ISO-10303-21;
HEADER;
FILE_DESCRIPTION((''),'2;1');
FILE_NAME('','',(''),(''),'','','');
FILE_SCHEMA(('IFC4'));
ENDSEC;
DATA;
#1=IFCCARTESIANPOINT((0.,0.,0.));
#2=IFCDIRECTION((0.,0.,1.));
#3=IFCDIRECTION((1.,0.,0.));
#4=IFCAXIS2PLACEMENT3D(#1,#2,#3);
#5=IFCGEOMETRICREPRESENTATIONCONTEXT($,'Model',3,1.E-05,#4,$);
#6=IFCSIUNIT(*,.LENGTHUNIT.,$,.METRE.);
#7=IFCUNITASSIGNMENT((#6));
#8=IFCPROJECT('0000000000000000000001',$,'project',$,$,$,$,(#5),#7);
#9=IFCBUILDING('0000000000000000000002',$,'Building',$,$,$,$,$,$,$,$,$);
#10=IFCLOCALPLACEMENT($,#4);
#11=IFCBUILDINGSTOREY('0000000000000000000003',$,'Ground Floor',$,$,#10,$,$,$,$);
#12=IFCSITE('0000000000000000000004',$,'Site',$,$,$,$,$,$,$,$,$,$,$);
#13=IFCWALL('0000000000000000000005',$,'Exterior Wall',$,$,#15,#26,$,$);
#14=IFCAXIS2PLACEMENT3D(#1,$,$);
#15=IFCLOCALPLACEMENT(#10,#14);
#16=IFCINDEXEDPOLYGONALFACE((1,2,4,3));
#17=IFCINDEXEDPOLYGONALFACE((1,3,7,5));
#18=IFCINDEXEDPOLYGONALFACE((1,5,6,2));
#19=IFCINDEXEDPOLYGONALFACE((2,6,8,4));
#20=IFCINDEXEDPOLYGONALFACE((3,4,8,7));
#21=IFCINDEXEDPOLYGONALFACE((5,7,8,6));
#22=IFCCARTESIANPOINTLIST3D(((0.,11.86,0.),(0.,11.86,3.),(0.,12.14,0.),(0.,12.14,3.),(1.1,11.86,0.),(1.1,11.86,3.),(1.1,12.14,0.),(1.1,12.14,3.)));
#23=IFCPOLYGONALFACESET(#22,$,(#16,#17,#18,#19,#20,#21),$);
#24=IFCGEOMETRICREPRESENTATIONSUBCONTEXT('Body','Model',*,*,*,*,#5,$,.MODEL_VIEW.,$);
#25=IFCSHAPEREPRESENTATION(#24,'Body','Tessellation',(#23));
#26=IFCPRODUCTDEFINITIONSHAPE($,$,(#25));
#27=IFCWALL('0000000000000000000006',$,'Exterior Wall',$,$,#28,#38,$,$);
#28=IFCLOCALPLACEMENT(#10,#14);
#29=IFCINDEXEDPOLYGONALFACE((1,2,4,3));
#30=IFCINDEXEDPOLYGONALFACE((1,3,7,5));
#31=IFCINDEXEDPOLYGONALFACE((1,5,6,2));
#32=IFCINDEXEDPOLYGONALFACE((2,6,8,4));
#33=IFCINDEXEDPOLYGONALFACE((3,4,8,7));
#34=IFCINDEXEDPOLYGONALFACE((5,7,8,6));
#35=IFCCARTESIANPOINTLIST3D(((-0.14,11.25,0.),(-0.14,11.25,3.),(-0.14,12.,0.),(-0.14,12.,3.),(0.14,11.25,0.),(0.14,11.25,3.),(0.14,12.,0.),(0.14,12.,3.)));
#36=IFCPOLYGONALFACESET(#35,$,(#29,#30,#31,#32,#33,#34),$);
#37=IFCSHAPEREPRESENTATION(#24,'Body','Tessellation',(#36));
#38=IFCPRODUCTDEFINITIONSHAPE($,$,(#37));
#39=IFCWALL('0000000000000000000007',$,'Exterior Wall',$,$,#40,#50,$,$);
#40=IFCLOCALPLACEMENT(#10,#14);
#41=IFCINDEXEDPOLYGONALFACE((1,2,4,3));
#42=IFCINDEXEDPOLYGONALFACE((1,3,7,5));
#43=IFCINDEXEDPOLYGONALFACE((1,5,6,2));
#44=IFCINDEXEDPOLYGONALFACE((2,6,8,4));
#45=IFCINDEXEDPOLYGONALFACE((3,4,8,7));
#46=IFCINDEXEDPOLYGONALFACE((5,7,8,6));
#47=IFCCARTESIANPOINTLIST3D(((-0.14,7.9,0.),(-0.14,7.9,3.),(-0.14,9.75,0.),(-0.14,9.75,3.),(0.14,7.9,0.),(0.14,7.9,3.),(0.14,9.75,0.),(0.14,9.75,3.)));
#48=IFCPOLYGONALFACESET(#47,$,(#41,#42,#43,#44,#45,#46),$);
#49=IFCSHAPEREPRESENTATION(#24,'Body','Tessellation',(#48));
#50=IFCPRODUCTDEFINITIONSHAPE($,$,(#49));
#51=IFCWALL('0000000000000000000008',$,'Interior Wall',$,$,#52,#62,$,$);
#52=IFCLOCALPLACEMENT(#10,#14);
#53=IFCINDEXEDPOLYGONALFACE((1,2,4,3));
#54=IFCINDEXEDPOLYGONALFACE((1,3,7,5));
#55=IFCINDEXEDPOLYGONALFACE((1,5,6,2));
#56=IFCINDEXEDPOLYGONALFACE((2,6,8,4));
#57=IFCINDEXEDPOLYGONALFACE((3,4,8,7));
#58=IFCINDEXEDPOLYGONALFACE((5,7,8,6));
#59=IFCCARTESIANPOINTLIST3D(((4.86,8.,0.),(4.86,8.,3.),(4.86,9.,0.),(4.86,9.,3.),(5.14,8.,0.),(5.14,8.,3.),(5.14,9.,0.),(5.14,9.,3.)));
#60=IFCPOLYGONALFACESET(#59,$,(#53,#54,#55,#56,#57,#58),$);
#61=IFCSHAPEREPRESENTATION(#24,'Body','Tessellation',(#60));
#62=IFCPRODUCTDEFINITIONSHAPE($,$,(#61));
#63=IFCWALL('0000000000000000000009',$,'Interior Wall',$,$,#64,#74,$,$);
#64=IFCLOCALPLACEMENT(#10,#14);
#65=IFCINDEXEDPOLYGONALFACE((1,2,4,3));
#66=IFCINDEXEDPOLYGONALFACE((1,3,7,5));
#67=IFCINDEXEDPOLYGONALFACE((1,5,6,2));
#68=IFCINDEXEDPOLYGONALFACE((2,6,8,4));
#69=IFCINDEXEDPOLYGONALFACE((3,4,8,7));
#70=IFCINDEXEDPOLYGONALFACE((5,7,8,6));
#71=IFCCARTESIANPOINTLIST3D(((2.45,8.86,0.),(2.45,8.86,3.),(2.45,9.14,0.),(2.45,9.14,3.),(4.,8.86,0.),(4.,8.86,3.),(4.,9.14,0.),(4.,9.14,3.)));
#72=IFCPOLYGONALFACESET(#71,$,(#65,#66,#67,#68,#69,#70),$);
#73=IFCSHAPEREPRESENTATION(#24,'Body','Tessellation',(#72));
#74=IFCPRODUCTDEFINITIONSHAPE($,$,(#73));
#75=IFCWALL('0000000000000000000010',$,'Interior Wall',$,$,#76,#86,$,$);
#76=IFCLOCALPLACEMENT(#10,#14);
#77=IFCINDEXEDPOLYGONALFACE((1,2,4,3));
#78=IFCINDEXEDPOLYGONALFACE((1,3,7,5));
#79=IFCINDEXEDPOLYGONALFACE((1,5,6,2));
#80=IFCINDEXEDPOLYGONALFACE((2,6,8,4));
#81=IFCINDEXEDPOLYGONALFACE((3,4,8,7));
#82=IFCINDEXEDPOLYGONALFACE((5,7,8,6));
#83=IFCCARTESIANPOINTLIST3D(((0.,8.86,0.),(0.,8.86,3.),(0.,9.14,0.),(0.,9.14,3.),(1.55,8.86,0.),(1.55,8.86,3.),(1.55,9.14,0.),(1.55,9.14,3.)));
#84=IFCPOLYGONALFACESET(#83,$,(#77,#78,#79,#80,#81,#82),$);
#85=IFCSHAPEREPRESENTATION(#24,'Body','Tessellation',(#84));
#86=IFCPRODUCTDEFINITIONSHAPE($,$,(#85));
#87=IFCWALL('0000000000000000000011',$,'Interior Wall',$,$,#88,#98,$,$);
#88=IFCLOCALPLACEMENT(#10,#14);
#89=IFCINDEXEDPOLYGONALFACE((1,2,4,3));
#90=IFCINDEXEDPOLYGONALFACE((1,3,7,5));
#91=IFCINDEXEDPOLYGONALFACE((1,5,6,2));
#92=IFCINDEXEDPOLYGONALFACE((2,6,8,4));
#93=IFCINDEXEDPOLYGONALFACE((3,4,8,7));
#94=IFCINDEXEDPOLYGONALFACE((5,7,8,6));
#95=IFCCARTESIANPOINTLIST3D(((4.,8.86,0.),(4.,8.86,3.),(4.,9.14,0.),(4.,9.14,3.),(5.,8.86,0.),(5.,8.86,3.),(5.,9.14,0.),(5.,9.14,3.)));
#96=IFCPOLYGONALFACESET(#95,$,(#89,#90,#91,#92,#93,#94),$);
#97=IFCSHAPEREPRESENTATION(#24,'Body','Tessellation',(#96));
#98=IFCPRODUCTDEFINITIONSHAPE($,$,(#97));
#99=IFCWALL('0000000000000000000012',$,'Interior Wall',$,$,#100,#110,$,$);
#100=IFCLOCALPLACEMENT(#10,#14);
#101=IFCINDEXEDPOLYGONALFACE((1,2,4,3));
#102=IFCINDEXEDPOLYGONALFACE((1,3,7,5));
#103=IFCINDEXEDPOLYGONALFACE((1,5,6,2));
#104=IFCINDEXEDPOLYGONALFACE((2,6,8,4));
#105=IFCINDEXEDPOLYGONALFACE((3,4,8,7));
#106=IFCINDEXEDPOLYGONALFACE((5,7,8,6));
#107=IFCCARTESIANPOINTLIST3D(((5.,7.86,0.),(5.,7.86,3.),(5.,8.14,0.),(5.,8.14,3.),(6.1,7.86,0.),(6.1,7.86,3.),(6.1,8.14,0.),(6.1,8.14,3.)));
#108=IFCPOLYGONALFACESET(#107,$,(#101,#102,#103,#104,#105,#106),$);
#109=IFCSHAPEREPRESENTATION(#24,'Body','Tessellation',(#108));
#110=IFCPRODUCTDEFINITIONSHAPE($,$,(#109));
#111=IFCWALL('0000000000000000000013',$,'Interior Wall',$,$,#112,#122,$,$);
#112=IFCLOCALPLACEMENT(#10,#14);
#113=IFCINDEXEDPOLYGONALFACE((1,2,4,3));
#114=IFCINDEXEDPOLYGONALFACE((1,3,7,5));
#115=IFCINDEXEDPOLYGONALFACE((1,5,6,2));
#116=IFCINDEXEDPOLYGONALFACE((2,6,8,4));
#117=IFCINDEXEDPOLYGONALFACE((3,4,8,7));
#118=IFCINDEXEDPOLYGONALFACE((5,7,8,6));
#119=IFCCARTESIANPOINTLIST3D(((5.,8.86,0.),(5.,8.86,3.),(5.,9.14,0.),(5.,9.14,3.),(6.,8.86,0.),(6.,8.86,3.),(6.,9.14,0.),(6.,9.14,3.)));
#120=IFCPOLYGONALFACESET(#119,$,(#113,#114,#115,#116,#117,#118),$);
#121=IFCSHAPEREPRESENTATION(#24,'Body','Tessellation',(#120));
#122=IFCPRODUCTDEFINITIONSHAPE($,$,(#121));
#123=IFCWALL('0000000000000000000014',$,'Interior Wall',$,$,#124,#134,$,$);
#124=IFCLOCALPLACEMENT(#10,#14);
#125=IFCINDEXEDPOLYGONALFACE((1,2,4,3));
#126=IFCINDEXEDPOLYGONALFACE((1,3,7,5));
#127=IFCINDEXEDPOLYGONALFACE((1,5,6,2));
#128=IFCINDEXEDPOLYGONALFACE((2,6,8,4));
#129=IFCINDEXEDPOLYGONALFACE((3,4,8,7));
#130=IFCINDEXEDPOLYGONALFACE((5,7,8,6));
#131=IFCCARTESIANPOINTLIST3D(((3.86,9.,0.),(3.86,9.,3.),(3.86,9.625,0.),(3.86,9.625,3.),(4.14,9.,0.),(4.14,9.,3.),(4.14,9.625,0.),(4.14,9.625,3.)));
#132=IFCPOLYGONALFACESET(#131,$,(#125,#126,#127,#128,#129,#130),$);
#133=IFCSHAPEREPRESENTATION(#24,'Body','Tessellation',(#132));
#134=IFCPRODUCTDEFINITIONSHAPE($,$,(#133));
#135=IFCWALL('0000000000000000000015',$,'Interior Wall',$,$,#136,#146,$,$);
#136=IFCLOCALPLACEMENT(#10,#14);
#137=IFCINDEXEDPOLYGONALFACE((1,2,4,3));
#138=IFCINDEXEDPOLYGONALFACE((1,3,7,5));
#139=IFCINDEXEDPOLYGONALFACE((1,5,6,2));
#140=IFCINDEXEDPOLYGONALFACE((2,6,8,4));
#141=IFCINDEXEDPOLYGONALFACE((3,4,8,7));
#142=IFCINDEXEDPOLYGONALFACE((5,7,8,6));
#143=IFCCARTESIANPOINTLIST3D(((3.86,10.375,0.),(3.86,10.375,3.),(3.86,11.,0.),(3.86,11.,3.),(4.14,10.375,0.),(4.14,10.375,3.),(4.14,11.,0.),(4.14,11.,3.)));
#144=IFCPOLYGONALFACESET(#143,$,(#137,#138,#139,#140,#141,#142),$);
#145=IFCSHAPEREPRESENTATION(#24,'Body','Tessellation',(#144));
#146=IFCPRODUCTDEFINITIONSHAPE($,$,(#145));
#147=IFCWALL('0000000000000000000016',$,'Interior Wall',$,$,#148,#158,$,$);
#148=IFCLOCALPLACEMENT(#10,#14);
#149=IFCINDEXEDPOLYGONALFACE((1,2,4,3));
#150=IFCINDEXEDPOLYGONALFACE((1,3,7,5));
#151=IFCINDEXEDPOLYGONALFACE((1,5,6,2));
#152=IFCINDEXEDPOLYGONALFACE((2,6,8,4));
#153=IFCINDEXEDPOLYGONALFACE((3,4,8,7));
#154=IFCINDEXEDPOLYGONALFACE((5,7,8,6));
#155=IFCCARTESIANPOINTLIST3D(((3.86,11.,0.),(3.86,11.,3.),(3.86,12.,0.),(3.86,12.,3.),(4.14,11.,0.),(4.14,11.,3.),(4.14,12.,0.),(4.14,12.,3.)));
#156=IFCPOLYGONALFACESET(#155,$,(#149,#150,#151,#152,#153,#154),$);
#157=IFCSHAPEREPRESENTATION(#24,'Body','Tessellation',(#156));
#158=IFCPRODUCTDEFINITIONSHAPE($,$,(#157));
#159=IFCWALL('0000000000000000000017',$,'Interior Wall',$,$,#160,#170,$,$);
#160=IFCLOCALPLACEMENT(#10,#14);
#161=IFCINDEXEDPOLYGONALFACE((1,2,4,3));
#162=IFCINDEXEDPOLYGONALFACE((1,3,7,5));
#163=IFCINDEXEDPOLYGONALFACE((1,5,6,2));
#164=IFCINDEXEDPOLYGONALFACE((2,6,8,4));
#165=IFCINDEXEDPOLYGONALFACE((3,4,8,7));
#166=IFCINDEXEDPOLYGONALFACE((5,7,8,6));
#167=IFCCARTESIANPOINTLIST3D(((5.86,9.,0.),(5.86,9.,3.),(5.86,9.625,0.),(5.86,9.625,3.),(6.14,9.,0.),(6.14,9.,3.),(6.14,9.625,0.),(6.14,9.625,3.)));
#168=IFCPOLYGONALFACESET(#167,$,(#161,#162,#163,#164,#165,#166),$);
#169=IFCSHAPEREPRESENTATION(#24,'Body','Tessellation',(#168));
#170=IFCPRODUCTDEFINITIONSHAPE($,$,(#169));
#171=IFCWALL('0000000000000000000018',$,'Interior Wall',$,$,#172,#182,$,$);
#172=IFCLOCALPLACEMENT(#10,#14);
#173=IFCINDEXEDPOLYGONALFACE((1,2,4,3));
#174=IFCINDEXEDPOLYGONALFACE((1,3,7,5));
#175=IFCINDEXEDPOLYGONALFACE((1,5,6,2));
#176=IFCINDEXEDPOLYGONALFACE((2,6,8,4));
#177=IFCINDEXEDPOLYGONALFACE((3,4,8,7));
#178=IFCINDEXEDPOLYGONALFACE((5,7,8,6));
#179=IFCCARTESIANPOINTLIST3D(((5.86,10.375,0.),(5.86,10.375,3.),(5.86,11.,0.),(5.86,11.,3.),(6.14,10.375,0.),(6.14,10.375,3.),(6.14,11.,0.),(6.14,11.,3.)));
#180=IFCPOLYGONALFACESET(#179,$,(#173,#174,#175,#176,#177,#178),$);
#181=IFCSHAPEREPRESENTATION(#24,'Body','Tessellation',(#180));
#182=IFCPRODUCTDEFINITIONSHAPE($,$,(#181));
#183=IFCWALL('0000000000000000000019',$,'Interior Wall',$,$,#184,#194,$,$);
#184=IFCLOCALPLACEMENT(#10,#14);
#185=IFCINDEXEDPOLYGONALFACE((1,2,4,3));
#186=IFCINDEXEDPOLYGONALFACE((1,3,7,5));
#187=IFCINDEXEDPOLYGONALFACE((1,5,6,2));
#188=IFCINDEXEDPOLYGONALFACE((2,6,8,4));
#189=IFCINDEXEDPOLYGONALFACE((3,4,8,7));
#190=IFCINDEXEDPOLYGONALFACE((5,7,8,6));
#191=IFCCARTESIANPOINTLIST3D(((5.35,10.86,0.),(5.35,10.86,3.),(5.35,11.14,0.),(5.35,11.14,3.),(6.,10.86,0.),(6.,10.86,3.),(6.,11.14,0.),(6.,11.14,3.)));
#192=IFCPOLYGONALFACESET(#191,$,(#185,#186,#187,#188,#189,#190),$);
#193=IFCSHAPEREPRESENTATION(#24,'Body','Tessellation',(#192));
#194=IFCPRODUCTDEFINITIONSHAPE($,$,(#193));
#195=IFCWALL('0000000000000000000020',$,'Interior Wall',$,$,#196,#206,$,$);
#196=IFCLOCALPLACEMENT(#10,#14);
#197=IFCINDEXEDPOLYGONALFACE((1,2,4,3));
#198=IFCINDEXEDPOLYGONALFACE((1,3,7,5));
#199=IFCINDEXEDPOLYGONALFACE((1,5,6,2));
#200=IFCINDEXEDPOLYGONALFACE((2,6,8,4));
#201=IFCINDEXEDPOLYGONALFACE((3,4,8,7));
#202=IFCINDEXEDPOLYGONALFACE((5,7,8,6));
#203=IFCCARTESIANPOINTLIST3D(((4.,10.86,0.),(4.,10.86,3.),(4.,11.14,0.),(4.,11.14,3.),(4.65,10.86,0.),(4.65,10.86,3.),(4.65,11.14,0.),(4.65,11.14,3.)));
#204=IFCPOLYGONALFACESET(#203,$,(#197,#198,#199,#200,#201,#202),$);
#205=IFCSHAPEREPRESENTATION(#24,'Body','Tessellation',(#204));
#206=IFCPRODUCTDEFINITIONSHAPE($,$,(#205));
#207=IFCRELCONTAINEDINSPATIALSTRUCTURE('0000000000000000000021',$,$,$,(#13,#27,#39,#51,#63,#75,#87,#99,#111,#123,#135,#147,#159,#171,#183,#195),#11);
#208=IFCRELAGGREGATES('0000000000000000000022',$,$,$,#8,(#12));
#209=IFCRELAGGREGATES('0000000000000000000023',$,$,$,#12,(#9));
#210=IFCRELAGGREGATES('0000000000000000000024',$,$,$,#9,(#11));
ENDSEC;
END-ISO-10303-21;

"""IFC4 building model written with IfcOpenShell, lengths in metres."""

from ifc_helpers import new_model, si_unit, frame, origin_with_axes, place, context, subcontext, project, spatial, indexed_curve, outline, extrude, element, save


model = new_model("IFC4")

# Units and contexts
model_context = context("Model", 3, precision=1e-05, world=origin_with_axes())
body_context = subcontext(model_context, "Body", "Model", "MODEL_VIEW")
ifc_project = project(units=[si_unit("LENGTHUNIT", "METRE")], contexts=[model_context])

# Site, building, storey
site = spatial("IfcSite", under=ifc_project, Name="Site")
building = spatial("IfcBuilding", under=site, Name="Building")
storey_placement = place(None, origin_with_axes())
storey = spatial("IfcBuildingStorey", under=building, at=storey_placement, Name="Ground Floor")

# Walls
wall_1_placement = place(storey_placement, frame((1.1, 12.0, 0.0), z_axis=(0.0, 0.0, 1.0), x_axis=(-1.0, 0.0, 0.0)))
element("IfcWall", 1, at=wall_1_placement, inside=storey, Name="Exterior Wall", context=body_context, shape_type="SweptSolid", body=[
    extrude(outline(indexed_curve([(0.0, 0.0), (0.0, 0.28), (1.1, 0.28), (1.1, 0.0), (0.0, 0.0)], self_intersect=False)), frame((0.0, -0.14, 0.0), z_axis=(0.0, 0.0, 1.0), x_axis=(1.0, 0.0, 0.0)), (0.0, 0.0, 1.0), 3.0),
])
wall_2_placement = place(storey_placement, frame((0.0, 12.0, 0.0), z_axis=(0.0, 0.0, 1.0), x_axis=(0.0, -1.0, 0.0)))
element("IfcWall", 2, at=wall_2_placement, inside=storey, Name="Exterior Wall", context=body_context, shape_type="SweptSolid", body=[
    extrude(outline(indexed_curve([(0.0, 0.0), (0.0, 0.28), (0.75, 0.28), (0.75, 0.0), (0.0, 0.0)], self_intersect=False)), frame((0.0, -0.14, 0.0), z_axis=(0.0, 0.0, 1.0), x_axis=(1.0, 0.0, 0.0)), (0.0, 0.0, 1.0), 3.0),
])
wall_3_placement = place(storey_placement, frame((0.0, 9.75, 0.0), z_axis=(0.0, 0.0, 1.0), x_axis=(0.0, -1.0, 0.0)))
element("IfcWall", 3, at=wall_3_placement, inside=storey, Name="Exterior Wall", context=body_context, shape_type="SweptSolid", body=[
    extrude(outline(indexed_curve([(0.0, 0.0), (0.0, 0.28), (1.85, 0.28), (1.85, 0.0), (0.0, 0.0)], self_intersect=False)), frame((0.0, -0.14, 0.0), z_axis=(0.0, 0.0, 1.0), x_axis=(1.0, 0.0, 0.0)), (0.0, 0.0, 1.0), 3.0),
])
wall_4_placement = place(storey_placement, frame((5.0, 8.0, 0.0), z_axis=(0.0, 0.0, 1.0), x_axis=(0.0, 1.0, 0.0)))
element("IfcWall", 4, at=wall_4_placement, inside=storey, Name="Interior Wall", context=body_context, shape_type="SweptSolid", body=[
    extrude(outline(indexed_curve([(0.0, 0.0), (0.0, 0.28), (1.0, 0.28), (1.0, 0.0), (0.0, 0.0)], self_intersect=False)), frame((0.0, -0.14, 0.0), z_axis=(0.0, 0.0, 1.0), x_axis=(1.0, 0.0, 0.0)), (0.0, 0.0, 1.0), 3.0),
])
for number, where, z_axis, x_axis, name in (
    (5, (4.0, 9.0, 0.0), (0.0, 0.0, 1.0), (-1.0, 0.0, 0.0), "Interior Wall"),
    (6, (1.55, 9.0, 0.0), (0.0, 0.0, 1.0), (-1.0, 0.0, 0.0), "Interior Wall"),
):
    element("IfcWall", number, at=place(storey_placement, frame(where, z_axis=z_axis, x_axis=x_axis)), inside=storey, Name=name, context=body_context, shape_type="SweptSolid", body=[
        extrude(outline(indexed_curve([(0.0, 0.0), (0.0, 0.28), (1.55, 0.28), (1.55, 0.0), (0.0, 0.0)], self_intersect=False)), frame((0.0, -0.14, 0.0), z_axis=(0.0, 0.0, 1.0), x_axis=(1.0, 0.0, 0.0)), (0.0, 0.0, 1.0), 3.0),
    ])
wall_5_placement = place(storey_placement, frame((5.0, 9.0, 0.0), z_axis=(0.0, 0.0, 1.0), x_axis=(-1.0, 0.0, 0.0)))
element("IfcWall", 7, at=wall_5_placement, inside=storey, Name="Interior Wall", context=body_context, shape_type="SweptSolid", body=[
    extrude(outline(indexed_curve([(0.0, 0.0), (0.0, 0.28), (1.0, 0.28), (1.0, 0.0), (0.0, 0.0)], self_intersect=False)), frame((0.0, -0.14, 0.0), z_axis=(0.0, 0.0, 1.0), x_axis=(1.0, 0.0, 0.0)), (0.0, 0.0, 1.0), 3.0),
])
wall_6_placement = place(storey_placement, frame((6.1, 8.0, 0.0), z_axis=(0.0, 0.0, 1.0), x_axis=(-1.0, 0.0, 0.0)))
element("IfcWall", 8, at=wall_6_placement, inside=storey, Name="Interior Wall", context=body_context, shape_type="SweptSolid", body=[
    extrude(outline(indexed_curve([(0.0, 0.0), (0.0, 0.28), (1.1, 0.28), (1.1, 0.0), (0.0, 0.0)], self_intersect=False)), frame((0.0, -0.14, 0.0), z_axis=(0.0, 0.0, 1.0), x_axis=(1.0, 0.0, 0.0)), (0.0, 0.0, 1.0), 3.0),
])
wall_7_placement = place(storey_placement, frame((6.0, 9.0, 0.0), z_axis=(0.0, 0.0, 1.0), x_axis=(-1.0, 0.0, 0.0)))
element("IfcWall", 9, at=wall_7_placement, inside=storey, Name="Interior Wall", context=body_context, shape_type="SweptSolid", body=[
    extrude(outline(indexed_curve([(0.0, 0.0), (0.0, 0.28), (1.0, 0.28), (1.0, 0.0), (0.0, 0.0)], self_intersect=False)), frame((0.0, -0.14, 0.0), z_axis=(0.0, 0.0, 1.0), x_axis=(1.0, 0.0, 0.0)), (0.0, 0.0, 1.0), 3.0),
])
for number, where, z_axis, x_axis, name in (
    (10, (4.0, 9.0, 0.0), (0.0, 0.0, 1.0), (0.0, 1.0, 0.0), "Interior Wall"),
    (11, (4.0, 10.375, 0.0), (0.0, 0.0, 1.0), (0.0, 1.0, 0.0), "Interior Wall"),
):
    element("IfcWall", number, at=place(storey_placement, frame(where, z_axis=z_axis, x_axis=x_axis)), inside=storey, Name=name, context=body_context, shape_type="SweptSolid", body=[
        extrude(outline(indexed_curve([(0.0, 0.0), (0.0, 0.28), (0.625, 0.28), (0.625, 0.0), (0.0, 0.0)], self_intersect=False)), frame((0.0, -0.14, 0.0), z_axis=(0.0, 0.0, 1.0), x_axis=(1.0, 0.0, 0.0)), (0.0, 0.0, 1.0), 3.0),
    ])
wall_8_placement = place(storey_placement, frame((4.0, 11.0, 0.0), z_axis=(0.0, 0.0, 1.0), x_axis=(0.0, 1.0, 0.0)))
element("IfcWall", 12, at=wall_8_placement, inside=storey, Name="Interior Wall", context=body_context, shape_type="SweptSolid", body=[
    extrude(outline(indexed_curve([(0.0, 0.0), (0.0, 0.28), (1.0, 0.28), (1.0, 0.0), (0.0, 0.0)], self_intersect=False)), frame((0.0, -0.14, 0.0), z_axis=(0.0, 0.0, 1.0), x_axis=(1.0, 0.0, 0.0)), (0.0, 0.0, 1.0), 3.0),
])
for number, where, z_axis, x_axis, name in (
    (13, (6.0, 9.0, 0.0), (0.0, 0.0, 1.0), (0.0, 1.0, 0.0), "Interior Wall"),
    (14, (6.0, 10.375, 0.0), (0.0, 0.0, 1.0), (0.0, 1.0, 0.0), "Interior Wall"),
):
    element("IfcWall", number, at=place(storey_placement, frame(where, z_axis=z_axis, x_axis=x_axis)), inside=storey, Name=name, context=body_context, shape_type="SweptSolid", body=[
        extrude(outline(indexed_curve([(0.0, 0.0), (0.0, 0.28), (0.625, 0.28), (0.625, 0.0), (0.0, 0.0)], self_intersect=False)), frame((0.0, -0.14, 0.0), z_axis=(0.0, 0.0, 1.0), x_axis=(1.0, 0.0, 0.0)), (0.0, 0.0, 1.0), 3.0),
    ])
for number, where, z_axis, x_axis, name in (
    (15, (6.0, 11.0, 0.0), (0.0, 0.0, 1.0), (-1.0, 0.0, 0.0), "Interior Wall"),
    (16, (4.65, 11.0, 0.0), (0.0, 0.0, 1.0), (-1.0, 0.0, 0.0), "Interior Wall"),
):
    element("IfcWall", number, at=place(storey_placement, frame(where, z_axis=z_axis, x_axis=x_axis)), inside=storey, Name=name, context=body_context, shape_type="SweptSolid", body=[
        extrude(outline(indexed_curve([(0.0, 0.0), (0.0, 0.28), (0.65, 0.28), (0.65, 0.0), (0.0, 0.0)], self_intersect=False)), frame((0.0, -0.14, 0.0), z_axis=(0.0, 0.0, 1.0), x_axis=(1.0, 0.0, 0.0)), (0.0, 0.0, 1.0), 3.0),
    ])

save(model, "model.ifc")
